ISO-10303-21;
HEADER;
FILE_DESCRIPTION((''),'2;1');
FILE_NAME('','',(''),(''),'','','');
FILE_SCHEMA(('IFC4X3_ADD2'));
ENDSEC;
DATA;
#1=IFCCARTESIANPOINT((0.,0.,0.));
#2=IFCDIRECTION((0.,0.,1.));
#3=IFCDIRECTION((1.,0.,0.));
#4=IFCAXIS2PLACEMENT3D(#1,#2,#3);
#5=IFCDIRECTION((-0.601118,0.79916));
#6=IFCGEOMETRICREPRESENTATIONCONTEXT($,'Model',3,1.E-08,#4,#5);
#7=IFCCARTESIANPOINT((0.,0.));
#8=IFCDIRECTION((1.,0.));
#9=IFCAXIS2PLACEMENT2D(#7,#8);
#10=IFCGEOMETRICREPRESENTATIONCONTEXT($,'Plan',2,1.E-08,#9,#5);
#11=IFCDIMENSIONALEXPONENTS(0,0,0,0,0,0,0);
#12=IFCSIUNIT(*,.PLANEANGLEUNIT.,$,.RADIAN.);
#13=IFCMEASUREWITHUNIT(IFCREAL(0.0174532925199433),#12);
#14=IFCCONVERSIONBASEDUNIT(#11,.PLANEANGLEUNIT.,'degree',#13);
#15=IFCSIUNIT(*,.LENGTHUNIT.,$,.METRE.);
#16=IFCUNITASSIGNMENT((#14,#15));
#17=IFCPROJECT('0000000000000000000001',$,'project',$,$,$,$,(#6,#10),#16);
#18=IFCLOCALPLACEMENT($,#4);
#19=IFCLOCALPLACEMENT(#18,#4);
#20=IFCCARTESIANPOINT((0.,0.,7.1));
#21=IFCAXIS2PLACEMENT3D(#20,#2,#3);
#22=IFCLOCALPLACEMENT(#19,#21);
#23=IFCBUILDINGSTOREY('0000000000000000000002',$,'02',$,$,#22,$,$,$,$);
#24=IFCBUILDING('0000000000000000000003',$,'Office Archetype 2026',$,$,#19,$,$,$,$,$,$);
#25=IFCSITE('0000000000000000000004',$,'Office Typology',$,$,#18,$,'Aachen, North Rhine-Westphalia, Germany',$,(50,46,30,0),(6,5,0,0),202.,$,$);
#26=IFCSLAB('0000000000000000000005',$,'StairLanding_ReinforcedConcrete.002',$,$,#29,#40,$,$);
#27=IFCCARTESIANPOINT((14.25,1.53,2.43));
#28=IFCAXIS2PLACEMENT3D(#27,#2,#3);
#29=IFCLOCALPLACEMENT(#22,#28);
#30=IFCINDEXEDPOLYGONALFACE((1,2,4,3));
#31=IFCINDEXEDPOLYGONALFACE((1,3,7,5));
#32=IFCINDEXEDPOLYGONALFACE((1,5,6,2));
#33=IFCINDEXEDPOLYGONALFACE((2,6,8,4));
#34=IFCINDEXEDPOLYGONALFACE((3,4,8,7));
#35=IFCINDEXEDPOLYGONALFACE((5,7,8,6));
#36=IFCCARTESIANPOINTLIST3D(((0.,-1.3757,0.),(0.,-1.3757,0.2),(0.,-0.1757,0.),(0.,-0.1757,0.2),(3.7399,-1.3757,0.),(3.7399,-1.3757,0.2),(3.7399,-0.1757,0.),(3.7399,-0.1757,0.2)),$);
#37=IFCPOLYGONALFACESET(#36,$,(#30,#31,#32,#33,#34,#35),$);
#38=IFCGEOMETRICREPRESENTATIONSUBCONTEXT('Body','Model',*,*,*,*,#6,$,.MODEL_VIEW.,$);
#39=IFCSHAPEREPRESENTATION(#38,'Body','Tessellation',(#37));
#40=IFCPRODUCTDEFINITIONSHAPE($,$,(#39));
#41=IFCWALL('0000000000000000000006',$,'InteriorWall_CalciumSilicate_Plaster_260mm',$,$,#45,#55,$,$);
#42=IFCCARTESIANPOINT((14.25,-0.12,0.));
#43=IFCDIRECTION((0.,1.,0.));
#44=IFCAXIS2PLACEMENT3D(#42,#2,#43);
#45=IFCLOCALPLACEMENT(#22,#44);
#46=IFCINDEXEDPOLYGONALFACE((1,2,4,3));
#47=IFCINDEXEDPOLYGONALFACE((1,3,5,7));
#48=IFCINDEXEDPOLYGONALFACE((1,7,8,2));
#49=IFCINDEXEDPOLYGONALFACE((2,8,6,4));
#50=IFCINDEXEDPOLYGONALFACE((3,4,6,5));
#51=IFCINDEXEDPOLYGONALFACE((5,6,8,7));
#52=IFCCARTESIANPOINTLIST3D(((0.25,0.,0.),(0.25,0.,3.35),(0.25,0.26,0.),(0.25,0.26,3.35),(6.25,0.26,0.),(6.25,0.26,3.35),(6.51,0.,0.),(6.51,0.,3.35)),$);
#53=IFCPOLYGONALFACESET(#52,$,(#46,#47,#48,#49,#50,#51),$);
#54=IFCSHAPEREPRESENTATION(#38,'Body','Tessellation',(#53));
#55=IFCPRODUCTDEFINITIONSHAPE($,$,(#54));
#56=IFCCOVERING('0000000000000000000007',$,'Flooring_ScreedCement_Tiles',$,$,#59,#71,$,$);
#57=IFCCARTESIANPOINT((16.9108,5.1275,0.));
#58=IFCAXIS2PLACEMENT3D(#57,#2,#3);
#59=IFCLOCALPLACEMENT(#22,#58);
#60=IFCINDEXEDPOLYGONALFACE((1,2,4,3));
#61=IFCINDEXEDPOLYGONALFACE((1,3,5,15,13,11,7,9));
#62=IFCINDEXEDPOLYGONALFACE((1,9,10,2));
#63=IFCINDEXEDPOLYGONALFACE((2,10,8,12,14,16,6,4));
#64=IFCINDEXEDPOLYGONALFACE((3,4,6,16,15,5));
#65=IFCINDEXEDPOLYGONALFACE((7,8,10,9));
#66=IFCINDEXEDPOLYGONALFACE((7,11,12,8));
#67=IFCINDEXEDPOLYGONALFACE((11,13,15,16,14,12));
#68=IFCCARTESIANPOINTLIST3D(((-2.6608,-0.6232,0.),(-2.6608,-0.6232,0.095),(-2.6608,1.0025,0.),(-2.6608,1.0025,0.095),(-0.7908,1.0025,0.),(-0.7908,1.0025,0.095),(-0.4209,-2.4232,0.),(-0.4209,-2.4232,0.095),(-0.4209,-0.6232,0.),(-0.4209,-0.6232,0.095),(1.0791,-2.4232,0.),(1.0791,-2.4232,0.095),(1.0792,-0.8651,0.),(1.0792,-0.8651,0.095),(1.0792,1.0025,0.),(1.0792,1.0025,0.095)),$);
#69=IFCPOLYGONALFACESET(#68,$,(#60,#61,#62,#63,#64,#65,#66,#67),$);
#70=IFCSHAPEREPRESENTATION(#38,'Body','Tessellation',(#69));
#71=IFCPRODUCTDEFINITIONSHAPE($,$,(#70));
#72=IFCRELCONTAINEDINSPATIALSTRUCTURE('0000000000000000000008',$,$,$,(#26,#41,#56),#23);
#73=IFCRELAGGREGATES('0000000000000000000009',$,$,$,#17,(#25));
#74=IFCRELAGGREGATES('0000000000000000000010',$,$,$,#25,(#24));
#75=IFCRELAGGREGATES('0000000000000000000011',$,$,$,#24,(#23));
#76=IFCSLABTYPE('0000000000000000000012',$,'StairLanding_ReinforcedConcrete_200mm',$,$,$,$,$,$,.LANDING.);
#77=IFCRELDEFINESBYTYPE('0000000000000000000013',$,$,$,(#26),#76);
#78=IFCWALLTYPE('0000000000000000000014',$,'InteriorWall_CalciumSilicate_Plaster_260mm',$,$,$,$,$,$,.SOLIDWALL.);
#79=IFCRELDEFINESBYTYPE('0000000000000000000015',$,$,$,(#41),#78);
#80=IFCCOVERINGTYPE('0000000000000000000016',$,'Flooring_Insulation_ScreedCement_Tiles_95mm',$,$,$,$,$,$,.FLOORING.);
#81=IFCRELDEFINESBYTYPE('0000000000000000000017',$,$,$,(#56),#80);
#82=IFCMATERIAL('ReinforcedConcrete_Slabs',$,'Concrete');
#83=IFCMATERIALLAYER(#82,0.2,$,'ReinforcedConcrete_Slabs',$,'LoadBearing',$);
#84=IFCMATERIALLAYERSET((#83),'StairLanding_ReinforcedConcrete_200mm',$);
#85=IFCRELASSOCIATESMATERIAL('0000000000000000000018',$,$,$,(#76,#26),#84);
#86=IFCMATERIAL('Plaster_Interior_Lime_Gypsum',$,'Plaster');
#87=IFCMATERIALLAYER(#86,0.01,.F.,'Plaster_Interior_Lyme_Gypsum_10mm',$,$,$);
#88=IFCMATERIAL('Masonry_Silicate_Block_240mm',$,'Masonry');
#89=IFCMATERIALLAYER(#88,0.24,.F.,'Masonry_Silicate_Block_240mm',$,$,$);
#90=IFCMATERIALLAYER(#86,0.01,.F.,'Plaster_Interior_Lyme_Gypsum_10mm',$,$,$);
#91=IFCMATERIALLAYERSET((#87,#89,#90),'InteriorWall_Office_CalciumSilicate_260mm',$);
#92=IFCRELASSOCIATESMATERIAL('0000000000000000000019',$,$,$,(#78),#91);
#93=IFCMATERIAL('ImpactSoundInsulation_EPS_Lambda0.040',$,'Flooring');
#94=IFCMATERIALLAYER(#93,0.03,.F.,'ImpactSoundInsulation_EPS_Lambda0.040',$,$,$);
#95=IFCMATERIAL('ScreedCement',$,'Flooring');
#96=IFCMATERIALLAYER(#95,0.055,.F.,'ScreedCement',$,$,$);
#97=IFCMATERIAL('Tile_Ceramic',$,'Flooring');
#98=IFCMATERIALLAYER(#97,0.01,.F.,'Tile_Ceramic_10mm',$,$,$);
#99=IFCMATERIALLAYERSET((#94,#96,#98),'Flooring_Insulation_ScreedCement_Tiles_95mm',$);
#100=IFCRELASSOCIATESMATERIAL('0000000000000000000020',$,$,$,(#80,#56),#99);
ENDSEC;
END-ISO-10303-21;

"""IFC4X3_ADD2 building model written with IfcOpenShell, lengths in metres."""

from ifc_helpers import new_model, entity, si_unit, converted_unit, direction, frame, origin_with_axes, origin_2d_with_axis, place, context, subcontext, project, spatial, line, indexed_curve, outline, extrude, material, layer, layer_set, layer_usage, type_object, element, save


model = new_model("IFC4X3_ADD2")

# Units and contexts
model_context = context("Model", 3, precision=1e-08, world=origin_with_axes(), true_north=direction((-0.601118, 0.79916)))
plan_context = context("Plan", 2, precision=1e-08, world=origin_2d_with_axis(), true_north=direction((-0.601118, 0.79916)))
body_context = subcontext(model_context, "Body", "Model", "MODEL_VIEW")
ifc_project = project(units=[converted_unit("PLANEANGLEUNIT", "degree", entity("IfcReal", 0.0174532925199433), si_unit("PLANEANGLEUNIT", "RADIAN"), dimensions=[0, 0, 0, 0, 0, 0, 0]), si_unit("LENGTHUNIT", "METRE")], contexts=[model_context, plan_context])

# Site, building, storey
site_placement = place(None, origin_with_axes())
site = spatial("IfcSite", under=ifc_project, at=site_placement, Name="Office Typology", LongName="Aachen, North Rhine-Westphalia, Germany", RefLatitude=(50, 46, 30, 0), RefLongitude=(6, 5, 0, 0), RefElevation=202.0)
building_placement = place(site_placement, origin_with_axes())
building = spatial("IfcBuilding", under=site, at=building_placement, Name="Office Archetype 2026")
storey_placement = place(building_placement, frame((0.0, 0.0, 7.1), z_axis=(0.0, 0.0, 1.0), x_axis=(1.0, 0.0, 0.0)))
storey = spatial("IfcBuildingStorey", under=building, at=storey_placement, Name="02")

# Slab
ifc_material_1 = material(Name="ReinforcedConcrete_Slabs", Category="Concrete")
ifc_layer_1 = layer(ifc_material_1, 0.2, Name="ReinforcedConcrete_Slabs", Category="LoadBearing")
ifc_layer_set_1 = layer_set([ifc_layer_1], Name="StairLanding_ReinforcedConcrete_200mm")
ifc_layer_usage_1 = layer_usage(ifc_layer_set_1, "AXIS3", "POSITIVE", 0.0)
slab_type_1 = type_object("IfcSlabType", Name="StairLanding_ReinforcedConcrete_200mm", PredefinedType="LANDING", material=ifc_layer_set_1)
slab_1_placement = place(storey_placement, frame((14.25, 1.53, 2.43), z_axis=(0.0, 0.0, 1.0), x_axis=(1.0, 0.0, 0.0)))
element("IfcSlab", 1, at=slab_1_placement, inside=storey, type_object=slab_type_1, material=ifc_layer_usage_1, Name="StairLanding_ReinforcedConcrete.002", context=body_context, shape_type="SweptSolid", body=[
    extrude(outline(indexed_curve([(3.7399, -0.1757), (3.7399, -1.3757), (0.0, -1.3757), (0.0, -0.1757), (3.7399, -0.1757)])), None, (0.0, 0.0, 1.0), 0.2),
])

# Wall
ifc_material_2 = material(Name="Plaster_Interior_Lime_Gypsum", Category="Plaster")
ifc_layer_2 = layer(ifc_material_2, 0.01, ventilated=False, Name="Plaster_Interior_Lyme_Gypsum_10mm")
ifc_material_3 = material(Name="Masonry_Silicate_Block_240mm", Category="Masonry")
ifc_layer_3 = layer(ifc_material_3, 0.24, ventilated=False, Name="Masonry_Silicate_Block_240mm")
ifc_layer_4 = layer(ifc_material_2, 0.01, ventilated=False, Name="Plaster_Interior_Lyme_Gypsum_10mm")
ifc_layer_set_2 = layer_set([ifc_layer_2, ifc_layer_3, ifc_layer_4], Name="InteriorWall_Office_CalciumSilicate_260mm")
wall_type = type_object("IfcWallType", Name="InteriorWall_CalciumSilicate_Plaster_260mm", PredefinedType="SOLIDWALL", material=ifc_layer_set_2)
wall_placement = place(storey_placement, frame((14.25, -0.12, 0.0), z_axis=(0.0, 0.0, 1.0), x_axis=(0.0, 1.0, 0.0)))
element("IfcWall", 2, at=wall_placement, inside=storey, type_object=wall_type, Name="InteriorWall_CalciumSilicate_Plaster_260mm", context=body_context, shape_type="SweptSolid", body=[
    extrude(outline(indexed_curve([(0.25, 0.0), (0.25, 0.26), (6.25, 0.26), (6.51, 0.0)], segments=[line(1, 2, 3, 4, 1)])), origin_with_axes(), (0.0, 0.0, 1.0), 3.35),
])

# Covering
ifc_material_4 = material(Name="ImpactSoundInsulation_EPS_Lambda0.040", Category="Flooring")
ifc_layer_5 = layer(ifc_material_4, 0.03, ventilated=False, Name="ImpactSoundInsulation_EPS_Lambda0.040")
ifc_material_5 = material(Name="ScreedCement", Category="Flooring")
ifc_layer_6 = layer(ifc_material_5, 0.055, ventilated=False, Name="ScreedCement")
ifc_material_6 = material(Name="Tile_Ceramic", Category="Flooring")
ifc_layer_7 = layer(ifc_material_6, 0.01, ventilated=False, Name="Tile_Ceramic_10mm")
ifc_layer_set_3 = layer_set([ifc_layer_5, ifc_layer_6, ifc_layer_7], Name="Flooring_Insulation_ScreedCement_Tiles_95mm")
ifc_layer_usage_2 = layer_usage(ifc_layer_set_3, "AXIS3", "POSITIVE", 0.0)
covering_type = type_object("IfcCoveringType", Name="Flooring_Insulation_ScreedCement_Tiles_95mm", PredefinedType="FLOORING", material=ifc_layer_set_3)
covering_placement = place(storey_placement, frame((16.9108, 5.1275, 0.0), z_axis=(0.0, 0.0, 1.0), x_axis=(1.0, 0.0, 0.0)))
element("IfcCovering", 3, at=covering_placement, inside=storey, type_object=covering_type, material=ifc_layer_usage_2, Name="Flooring_ScreedCement_Tiles", context=body_context, shape_type="SweptSolid", body=[
    extrude(outline(indexed_curve([(-0.7908, 1.0025), (-2.6608, 1.0025), (-2.6608, -0.6232), (-0.4209, -0.6232), (-0.4209, -2.4232), (1.0791, -2.4232), (1.0792, -0.8651), (1.0792, 1.0025), (-0.7908, 1.0025)])), None, (0.0, 0.0, 1.0), 0.095),
])

save(model, "model.ifc")
